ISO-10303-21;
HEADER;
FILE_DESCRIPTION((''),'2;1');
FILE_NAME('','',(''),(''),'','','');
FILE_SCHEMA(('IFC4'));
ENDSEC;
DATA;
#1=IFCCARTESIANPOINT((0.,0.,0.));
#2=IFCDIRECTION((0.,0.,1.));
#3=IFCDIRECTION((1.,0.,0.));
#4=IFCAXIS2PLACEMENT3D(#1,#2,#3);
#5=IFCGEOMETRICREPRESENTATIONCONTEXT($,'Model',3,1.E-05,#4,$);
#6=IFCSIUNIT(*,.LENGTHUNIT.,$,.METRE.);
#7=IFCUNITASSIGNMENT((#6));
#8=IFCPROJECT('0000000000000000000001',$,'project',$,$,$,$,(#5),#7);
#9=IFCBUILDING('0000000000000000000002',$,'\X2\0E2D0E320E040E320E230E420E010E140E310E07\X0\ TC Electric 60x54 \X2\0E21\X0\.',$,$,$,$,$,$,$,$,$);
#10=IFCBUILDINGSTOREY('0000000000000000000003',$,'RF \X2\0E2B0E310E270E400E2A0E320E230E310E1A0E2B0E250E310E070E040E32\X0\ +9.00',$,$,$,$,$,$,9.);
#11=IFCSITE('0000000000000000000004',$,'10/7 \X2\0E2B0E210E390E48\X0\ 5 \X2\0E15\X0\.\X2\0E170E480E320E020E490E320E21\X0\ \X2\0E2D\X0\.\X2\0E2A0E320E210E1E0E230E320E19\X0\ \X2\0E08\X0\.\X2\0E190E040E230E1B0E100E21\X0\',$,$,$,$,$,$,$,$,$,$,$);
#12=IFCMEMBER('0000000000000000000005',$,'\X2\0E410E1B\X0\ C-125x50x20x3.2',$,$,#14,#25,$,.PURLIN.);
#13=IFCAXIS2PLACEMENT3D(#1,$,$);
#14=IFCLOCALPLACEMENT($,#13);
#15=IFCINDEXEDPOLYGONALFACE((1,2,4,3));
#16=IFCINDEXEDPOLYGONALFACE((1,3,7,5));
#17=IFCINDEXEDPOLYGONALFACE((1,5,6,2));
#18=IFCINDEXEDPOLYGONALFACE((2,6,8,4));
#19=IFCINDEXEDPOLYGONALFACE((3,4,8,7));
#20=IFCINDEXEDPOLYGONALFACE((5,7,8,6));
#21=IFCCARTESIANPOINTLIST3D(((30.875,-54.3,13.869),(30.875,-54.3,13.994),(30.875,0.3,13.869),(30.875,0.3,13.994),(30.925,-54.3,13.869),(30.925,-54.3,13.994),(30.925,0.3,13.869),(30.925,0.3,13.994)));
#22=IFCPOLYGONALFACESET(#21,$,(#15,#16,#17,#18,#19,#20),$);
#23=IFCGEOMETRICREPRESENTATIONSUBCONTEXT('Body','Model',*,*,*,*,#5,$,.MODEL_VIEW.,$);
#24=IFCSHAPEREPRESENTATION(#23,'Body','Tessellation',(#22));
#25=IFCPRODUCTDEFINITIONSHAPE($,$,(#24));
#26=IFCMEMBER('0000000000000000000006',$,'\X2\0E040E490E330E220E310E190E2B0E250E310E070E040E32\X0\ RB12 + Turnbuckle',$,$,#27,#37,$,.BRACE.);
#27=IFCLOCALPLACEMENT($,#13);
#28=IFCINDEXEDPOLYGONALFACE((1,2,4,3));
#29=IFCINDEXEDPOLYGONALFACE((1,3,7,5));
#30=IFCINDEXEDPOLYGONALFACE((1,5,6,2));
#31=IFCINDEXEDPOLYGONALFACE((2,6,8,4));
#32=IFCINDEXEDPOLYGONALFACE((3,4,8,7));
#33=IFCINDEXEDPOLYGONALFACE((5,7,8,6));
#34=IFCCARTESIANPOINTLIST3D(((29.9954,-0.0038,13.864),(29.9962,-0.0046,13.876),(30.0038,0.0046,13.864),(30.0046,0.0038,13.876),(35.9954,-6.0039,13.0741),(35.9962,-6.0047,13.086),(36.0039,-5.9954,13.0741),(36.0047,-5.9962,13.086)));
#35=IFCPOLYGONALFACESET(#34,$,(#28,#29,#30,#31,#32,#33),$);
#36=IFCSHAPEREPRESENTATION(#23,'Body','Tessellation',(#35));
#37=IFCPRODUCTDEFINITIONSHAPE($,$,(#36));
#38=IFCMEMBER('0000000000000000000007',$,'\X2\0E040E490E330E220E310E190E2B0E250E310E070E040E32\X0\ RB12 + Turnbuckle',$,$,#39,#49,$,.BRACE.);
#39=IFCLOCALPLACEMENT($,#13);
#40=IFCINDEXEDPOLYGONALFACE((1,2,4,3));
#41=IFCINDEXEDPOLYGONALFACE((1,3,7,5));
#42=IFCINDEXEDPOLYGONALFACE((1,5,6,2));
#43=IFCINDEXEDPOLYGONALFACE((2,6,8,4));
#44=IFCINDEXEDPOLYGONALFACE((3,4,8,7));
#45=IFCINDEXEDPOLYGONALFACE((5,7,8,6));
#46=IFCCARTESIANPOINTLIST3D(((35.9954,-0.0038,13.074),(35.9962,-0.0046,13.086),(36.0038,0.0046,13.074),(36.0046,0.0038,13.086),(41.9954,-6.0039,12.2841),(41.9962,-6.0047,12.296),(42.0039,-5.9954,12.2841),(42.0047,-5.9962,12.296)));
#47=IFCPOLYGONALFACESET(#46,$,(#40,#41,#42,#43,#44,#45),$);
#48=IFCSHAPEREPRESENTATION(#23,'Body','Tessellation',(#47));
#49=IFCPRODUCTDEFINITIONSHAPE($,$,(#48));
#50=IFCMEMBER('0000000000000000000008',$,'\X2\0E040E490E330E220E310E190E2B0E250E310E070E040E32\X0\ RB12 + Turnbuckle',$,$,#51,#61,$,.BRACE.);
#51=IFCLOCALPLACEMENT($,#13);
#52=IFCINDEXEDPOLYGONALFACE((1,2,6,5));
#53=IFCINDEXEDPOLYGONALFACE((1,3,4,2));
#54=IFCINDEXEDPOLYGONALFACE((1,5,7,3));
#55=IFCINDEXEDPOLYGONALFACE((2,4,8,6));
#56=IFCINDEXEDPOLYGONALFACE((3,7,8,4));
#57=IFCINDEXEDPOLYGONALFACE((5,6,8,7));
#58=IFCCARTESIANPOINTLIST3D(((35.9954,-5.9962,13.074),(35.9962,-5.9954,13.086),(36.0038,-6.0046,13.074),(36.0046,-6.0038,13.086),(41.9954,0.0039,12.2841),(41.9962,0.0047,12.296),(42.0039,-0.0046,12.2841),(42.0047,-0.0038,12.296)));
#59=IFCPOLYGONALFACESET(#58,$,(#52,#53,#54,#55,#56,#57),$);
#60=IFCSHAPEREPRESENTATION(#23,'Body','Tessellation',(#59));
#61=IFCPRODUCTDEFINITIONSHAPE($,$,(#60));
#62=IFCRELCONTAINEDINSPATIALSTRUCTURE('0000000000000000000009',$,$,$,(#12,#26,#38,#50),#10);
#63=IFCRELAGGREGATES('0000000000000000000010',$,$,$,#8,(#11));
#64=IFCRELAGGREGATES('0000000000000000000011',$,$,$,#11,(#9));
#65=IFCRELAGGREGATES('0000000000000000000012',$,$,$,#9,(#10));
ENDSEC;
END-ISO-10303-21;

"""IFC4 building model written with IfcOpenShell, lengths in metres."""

from ifc_helpers import new_model, si_unit, frame, origin, origin_with_axes, origin_2d, place, context, subcontext, project, spatial, rectangle, extrude, element, save


model = new_model("IFC4")

# Units and contexts
model_context = context("Model", 3, precision=1e-05, world=origin_with_axes())
body_context = subcontext(model_context, "Body", "Model", "MODEL_VIEW")
ifc_project = project(units=[si_unit("LENGTHUNIT", "METRE")], contexts=[model_context])

# Site, building, storey
site = spatial("IfcSite", under=ifc_project, Name="10/7 หมู่ 5 ต.ท่าข้าม อ.สามพราน จ.นครปฐม")
building = spatial("IfcBuilding", under=site, Name="อาคารโกดัง TC Electric 60x54 ม.")
storey = spatial("IfcBuildingStorey", under=building, Name="RF หัวเสารับหลังคา +9.00", Elevation=9.0)

# Members
for number, where, z_axis, x_axis, name in (
    (1, (30.9, 0.3, 13.9315), (0.0, -1.0, 0.0), (-1.0, 0.0, 0.0), "แป C-125x50x20x3.2"),
):
    element("IfcMember", number, at=place(None, frame(where, z_axis=z_axis, x_axis=x_axis)), inside=storey, Name=name, PredefinedType="PURLIN", context=body_context, shape_type="SweptSolid", body=[
        extrude(rectangle(XDim=0.05, YDim=0.125, at=origin_2d()), origin(), (0.0, 0.0, 1.0), 54.6),
    ])
for number, where, z_axis, x_axis, name in (
    (2, (30.0, 0.0, 13.87), (0.7041, -0.7041, -0.0927), (-0.7071, -0.7071, 0.0), "ค้ำยันหลังคา RB12 + Turnbuckle"),
    (3, (36.0, 0.0, 13.08), (0.7041, -0.7041, -0.0927), (-0.7071, -0.7071, 0.0), "ค้ำยันหลังคา RB12 + Turnbuckle"),
    (4, (36.0, -6.0, 13.08), (0.7041, 0.7041, -0.0927), (0.7071, -0.7071, 0.0), "ค้ำยันหลังคา RB12 + Turnbuckle"),
):
    element("IfcMember", number, at=place(None, frame(where, z_axis=z_axis, x_axis=x_axis)), inside=storey, Name=name, PredefinedType="BRACE", context=body_context, shape_type="SweptSolid", body=[
        extrude(rectangle(XDim=0.012, YDim=0.012, at=origin_2d()), origin(), (0.0, 0.0, 1.0), 8.522),
    ])

save(model, "model.ifc")
